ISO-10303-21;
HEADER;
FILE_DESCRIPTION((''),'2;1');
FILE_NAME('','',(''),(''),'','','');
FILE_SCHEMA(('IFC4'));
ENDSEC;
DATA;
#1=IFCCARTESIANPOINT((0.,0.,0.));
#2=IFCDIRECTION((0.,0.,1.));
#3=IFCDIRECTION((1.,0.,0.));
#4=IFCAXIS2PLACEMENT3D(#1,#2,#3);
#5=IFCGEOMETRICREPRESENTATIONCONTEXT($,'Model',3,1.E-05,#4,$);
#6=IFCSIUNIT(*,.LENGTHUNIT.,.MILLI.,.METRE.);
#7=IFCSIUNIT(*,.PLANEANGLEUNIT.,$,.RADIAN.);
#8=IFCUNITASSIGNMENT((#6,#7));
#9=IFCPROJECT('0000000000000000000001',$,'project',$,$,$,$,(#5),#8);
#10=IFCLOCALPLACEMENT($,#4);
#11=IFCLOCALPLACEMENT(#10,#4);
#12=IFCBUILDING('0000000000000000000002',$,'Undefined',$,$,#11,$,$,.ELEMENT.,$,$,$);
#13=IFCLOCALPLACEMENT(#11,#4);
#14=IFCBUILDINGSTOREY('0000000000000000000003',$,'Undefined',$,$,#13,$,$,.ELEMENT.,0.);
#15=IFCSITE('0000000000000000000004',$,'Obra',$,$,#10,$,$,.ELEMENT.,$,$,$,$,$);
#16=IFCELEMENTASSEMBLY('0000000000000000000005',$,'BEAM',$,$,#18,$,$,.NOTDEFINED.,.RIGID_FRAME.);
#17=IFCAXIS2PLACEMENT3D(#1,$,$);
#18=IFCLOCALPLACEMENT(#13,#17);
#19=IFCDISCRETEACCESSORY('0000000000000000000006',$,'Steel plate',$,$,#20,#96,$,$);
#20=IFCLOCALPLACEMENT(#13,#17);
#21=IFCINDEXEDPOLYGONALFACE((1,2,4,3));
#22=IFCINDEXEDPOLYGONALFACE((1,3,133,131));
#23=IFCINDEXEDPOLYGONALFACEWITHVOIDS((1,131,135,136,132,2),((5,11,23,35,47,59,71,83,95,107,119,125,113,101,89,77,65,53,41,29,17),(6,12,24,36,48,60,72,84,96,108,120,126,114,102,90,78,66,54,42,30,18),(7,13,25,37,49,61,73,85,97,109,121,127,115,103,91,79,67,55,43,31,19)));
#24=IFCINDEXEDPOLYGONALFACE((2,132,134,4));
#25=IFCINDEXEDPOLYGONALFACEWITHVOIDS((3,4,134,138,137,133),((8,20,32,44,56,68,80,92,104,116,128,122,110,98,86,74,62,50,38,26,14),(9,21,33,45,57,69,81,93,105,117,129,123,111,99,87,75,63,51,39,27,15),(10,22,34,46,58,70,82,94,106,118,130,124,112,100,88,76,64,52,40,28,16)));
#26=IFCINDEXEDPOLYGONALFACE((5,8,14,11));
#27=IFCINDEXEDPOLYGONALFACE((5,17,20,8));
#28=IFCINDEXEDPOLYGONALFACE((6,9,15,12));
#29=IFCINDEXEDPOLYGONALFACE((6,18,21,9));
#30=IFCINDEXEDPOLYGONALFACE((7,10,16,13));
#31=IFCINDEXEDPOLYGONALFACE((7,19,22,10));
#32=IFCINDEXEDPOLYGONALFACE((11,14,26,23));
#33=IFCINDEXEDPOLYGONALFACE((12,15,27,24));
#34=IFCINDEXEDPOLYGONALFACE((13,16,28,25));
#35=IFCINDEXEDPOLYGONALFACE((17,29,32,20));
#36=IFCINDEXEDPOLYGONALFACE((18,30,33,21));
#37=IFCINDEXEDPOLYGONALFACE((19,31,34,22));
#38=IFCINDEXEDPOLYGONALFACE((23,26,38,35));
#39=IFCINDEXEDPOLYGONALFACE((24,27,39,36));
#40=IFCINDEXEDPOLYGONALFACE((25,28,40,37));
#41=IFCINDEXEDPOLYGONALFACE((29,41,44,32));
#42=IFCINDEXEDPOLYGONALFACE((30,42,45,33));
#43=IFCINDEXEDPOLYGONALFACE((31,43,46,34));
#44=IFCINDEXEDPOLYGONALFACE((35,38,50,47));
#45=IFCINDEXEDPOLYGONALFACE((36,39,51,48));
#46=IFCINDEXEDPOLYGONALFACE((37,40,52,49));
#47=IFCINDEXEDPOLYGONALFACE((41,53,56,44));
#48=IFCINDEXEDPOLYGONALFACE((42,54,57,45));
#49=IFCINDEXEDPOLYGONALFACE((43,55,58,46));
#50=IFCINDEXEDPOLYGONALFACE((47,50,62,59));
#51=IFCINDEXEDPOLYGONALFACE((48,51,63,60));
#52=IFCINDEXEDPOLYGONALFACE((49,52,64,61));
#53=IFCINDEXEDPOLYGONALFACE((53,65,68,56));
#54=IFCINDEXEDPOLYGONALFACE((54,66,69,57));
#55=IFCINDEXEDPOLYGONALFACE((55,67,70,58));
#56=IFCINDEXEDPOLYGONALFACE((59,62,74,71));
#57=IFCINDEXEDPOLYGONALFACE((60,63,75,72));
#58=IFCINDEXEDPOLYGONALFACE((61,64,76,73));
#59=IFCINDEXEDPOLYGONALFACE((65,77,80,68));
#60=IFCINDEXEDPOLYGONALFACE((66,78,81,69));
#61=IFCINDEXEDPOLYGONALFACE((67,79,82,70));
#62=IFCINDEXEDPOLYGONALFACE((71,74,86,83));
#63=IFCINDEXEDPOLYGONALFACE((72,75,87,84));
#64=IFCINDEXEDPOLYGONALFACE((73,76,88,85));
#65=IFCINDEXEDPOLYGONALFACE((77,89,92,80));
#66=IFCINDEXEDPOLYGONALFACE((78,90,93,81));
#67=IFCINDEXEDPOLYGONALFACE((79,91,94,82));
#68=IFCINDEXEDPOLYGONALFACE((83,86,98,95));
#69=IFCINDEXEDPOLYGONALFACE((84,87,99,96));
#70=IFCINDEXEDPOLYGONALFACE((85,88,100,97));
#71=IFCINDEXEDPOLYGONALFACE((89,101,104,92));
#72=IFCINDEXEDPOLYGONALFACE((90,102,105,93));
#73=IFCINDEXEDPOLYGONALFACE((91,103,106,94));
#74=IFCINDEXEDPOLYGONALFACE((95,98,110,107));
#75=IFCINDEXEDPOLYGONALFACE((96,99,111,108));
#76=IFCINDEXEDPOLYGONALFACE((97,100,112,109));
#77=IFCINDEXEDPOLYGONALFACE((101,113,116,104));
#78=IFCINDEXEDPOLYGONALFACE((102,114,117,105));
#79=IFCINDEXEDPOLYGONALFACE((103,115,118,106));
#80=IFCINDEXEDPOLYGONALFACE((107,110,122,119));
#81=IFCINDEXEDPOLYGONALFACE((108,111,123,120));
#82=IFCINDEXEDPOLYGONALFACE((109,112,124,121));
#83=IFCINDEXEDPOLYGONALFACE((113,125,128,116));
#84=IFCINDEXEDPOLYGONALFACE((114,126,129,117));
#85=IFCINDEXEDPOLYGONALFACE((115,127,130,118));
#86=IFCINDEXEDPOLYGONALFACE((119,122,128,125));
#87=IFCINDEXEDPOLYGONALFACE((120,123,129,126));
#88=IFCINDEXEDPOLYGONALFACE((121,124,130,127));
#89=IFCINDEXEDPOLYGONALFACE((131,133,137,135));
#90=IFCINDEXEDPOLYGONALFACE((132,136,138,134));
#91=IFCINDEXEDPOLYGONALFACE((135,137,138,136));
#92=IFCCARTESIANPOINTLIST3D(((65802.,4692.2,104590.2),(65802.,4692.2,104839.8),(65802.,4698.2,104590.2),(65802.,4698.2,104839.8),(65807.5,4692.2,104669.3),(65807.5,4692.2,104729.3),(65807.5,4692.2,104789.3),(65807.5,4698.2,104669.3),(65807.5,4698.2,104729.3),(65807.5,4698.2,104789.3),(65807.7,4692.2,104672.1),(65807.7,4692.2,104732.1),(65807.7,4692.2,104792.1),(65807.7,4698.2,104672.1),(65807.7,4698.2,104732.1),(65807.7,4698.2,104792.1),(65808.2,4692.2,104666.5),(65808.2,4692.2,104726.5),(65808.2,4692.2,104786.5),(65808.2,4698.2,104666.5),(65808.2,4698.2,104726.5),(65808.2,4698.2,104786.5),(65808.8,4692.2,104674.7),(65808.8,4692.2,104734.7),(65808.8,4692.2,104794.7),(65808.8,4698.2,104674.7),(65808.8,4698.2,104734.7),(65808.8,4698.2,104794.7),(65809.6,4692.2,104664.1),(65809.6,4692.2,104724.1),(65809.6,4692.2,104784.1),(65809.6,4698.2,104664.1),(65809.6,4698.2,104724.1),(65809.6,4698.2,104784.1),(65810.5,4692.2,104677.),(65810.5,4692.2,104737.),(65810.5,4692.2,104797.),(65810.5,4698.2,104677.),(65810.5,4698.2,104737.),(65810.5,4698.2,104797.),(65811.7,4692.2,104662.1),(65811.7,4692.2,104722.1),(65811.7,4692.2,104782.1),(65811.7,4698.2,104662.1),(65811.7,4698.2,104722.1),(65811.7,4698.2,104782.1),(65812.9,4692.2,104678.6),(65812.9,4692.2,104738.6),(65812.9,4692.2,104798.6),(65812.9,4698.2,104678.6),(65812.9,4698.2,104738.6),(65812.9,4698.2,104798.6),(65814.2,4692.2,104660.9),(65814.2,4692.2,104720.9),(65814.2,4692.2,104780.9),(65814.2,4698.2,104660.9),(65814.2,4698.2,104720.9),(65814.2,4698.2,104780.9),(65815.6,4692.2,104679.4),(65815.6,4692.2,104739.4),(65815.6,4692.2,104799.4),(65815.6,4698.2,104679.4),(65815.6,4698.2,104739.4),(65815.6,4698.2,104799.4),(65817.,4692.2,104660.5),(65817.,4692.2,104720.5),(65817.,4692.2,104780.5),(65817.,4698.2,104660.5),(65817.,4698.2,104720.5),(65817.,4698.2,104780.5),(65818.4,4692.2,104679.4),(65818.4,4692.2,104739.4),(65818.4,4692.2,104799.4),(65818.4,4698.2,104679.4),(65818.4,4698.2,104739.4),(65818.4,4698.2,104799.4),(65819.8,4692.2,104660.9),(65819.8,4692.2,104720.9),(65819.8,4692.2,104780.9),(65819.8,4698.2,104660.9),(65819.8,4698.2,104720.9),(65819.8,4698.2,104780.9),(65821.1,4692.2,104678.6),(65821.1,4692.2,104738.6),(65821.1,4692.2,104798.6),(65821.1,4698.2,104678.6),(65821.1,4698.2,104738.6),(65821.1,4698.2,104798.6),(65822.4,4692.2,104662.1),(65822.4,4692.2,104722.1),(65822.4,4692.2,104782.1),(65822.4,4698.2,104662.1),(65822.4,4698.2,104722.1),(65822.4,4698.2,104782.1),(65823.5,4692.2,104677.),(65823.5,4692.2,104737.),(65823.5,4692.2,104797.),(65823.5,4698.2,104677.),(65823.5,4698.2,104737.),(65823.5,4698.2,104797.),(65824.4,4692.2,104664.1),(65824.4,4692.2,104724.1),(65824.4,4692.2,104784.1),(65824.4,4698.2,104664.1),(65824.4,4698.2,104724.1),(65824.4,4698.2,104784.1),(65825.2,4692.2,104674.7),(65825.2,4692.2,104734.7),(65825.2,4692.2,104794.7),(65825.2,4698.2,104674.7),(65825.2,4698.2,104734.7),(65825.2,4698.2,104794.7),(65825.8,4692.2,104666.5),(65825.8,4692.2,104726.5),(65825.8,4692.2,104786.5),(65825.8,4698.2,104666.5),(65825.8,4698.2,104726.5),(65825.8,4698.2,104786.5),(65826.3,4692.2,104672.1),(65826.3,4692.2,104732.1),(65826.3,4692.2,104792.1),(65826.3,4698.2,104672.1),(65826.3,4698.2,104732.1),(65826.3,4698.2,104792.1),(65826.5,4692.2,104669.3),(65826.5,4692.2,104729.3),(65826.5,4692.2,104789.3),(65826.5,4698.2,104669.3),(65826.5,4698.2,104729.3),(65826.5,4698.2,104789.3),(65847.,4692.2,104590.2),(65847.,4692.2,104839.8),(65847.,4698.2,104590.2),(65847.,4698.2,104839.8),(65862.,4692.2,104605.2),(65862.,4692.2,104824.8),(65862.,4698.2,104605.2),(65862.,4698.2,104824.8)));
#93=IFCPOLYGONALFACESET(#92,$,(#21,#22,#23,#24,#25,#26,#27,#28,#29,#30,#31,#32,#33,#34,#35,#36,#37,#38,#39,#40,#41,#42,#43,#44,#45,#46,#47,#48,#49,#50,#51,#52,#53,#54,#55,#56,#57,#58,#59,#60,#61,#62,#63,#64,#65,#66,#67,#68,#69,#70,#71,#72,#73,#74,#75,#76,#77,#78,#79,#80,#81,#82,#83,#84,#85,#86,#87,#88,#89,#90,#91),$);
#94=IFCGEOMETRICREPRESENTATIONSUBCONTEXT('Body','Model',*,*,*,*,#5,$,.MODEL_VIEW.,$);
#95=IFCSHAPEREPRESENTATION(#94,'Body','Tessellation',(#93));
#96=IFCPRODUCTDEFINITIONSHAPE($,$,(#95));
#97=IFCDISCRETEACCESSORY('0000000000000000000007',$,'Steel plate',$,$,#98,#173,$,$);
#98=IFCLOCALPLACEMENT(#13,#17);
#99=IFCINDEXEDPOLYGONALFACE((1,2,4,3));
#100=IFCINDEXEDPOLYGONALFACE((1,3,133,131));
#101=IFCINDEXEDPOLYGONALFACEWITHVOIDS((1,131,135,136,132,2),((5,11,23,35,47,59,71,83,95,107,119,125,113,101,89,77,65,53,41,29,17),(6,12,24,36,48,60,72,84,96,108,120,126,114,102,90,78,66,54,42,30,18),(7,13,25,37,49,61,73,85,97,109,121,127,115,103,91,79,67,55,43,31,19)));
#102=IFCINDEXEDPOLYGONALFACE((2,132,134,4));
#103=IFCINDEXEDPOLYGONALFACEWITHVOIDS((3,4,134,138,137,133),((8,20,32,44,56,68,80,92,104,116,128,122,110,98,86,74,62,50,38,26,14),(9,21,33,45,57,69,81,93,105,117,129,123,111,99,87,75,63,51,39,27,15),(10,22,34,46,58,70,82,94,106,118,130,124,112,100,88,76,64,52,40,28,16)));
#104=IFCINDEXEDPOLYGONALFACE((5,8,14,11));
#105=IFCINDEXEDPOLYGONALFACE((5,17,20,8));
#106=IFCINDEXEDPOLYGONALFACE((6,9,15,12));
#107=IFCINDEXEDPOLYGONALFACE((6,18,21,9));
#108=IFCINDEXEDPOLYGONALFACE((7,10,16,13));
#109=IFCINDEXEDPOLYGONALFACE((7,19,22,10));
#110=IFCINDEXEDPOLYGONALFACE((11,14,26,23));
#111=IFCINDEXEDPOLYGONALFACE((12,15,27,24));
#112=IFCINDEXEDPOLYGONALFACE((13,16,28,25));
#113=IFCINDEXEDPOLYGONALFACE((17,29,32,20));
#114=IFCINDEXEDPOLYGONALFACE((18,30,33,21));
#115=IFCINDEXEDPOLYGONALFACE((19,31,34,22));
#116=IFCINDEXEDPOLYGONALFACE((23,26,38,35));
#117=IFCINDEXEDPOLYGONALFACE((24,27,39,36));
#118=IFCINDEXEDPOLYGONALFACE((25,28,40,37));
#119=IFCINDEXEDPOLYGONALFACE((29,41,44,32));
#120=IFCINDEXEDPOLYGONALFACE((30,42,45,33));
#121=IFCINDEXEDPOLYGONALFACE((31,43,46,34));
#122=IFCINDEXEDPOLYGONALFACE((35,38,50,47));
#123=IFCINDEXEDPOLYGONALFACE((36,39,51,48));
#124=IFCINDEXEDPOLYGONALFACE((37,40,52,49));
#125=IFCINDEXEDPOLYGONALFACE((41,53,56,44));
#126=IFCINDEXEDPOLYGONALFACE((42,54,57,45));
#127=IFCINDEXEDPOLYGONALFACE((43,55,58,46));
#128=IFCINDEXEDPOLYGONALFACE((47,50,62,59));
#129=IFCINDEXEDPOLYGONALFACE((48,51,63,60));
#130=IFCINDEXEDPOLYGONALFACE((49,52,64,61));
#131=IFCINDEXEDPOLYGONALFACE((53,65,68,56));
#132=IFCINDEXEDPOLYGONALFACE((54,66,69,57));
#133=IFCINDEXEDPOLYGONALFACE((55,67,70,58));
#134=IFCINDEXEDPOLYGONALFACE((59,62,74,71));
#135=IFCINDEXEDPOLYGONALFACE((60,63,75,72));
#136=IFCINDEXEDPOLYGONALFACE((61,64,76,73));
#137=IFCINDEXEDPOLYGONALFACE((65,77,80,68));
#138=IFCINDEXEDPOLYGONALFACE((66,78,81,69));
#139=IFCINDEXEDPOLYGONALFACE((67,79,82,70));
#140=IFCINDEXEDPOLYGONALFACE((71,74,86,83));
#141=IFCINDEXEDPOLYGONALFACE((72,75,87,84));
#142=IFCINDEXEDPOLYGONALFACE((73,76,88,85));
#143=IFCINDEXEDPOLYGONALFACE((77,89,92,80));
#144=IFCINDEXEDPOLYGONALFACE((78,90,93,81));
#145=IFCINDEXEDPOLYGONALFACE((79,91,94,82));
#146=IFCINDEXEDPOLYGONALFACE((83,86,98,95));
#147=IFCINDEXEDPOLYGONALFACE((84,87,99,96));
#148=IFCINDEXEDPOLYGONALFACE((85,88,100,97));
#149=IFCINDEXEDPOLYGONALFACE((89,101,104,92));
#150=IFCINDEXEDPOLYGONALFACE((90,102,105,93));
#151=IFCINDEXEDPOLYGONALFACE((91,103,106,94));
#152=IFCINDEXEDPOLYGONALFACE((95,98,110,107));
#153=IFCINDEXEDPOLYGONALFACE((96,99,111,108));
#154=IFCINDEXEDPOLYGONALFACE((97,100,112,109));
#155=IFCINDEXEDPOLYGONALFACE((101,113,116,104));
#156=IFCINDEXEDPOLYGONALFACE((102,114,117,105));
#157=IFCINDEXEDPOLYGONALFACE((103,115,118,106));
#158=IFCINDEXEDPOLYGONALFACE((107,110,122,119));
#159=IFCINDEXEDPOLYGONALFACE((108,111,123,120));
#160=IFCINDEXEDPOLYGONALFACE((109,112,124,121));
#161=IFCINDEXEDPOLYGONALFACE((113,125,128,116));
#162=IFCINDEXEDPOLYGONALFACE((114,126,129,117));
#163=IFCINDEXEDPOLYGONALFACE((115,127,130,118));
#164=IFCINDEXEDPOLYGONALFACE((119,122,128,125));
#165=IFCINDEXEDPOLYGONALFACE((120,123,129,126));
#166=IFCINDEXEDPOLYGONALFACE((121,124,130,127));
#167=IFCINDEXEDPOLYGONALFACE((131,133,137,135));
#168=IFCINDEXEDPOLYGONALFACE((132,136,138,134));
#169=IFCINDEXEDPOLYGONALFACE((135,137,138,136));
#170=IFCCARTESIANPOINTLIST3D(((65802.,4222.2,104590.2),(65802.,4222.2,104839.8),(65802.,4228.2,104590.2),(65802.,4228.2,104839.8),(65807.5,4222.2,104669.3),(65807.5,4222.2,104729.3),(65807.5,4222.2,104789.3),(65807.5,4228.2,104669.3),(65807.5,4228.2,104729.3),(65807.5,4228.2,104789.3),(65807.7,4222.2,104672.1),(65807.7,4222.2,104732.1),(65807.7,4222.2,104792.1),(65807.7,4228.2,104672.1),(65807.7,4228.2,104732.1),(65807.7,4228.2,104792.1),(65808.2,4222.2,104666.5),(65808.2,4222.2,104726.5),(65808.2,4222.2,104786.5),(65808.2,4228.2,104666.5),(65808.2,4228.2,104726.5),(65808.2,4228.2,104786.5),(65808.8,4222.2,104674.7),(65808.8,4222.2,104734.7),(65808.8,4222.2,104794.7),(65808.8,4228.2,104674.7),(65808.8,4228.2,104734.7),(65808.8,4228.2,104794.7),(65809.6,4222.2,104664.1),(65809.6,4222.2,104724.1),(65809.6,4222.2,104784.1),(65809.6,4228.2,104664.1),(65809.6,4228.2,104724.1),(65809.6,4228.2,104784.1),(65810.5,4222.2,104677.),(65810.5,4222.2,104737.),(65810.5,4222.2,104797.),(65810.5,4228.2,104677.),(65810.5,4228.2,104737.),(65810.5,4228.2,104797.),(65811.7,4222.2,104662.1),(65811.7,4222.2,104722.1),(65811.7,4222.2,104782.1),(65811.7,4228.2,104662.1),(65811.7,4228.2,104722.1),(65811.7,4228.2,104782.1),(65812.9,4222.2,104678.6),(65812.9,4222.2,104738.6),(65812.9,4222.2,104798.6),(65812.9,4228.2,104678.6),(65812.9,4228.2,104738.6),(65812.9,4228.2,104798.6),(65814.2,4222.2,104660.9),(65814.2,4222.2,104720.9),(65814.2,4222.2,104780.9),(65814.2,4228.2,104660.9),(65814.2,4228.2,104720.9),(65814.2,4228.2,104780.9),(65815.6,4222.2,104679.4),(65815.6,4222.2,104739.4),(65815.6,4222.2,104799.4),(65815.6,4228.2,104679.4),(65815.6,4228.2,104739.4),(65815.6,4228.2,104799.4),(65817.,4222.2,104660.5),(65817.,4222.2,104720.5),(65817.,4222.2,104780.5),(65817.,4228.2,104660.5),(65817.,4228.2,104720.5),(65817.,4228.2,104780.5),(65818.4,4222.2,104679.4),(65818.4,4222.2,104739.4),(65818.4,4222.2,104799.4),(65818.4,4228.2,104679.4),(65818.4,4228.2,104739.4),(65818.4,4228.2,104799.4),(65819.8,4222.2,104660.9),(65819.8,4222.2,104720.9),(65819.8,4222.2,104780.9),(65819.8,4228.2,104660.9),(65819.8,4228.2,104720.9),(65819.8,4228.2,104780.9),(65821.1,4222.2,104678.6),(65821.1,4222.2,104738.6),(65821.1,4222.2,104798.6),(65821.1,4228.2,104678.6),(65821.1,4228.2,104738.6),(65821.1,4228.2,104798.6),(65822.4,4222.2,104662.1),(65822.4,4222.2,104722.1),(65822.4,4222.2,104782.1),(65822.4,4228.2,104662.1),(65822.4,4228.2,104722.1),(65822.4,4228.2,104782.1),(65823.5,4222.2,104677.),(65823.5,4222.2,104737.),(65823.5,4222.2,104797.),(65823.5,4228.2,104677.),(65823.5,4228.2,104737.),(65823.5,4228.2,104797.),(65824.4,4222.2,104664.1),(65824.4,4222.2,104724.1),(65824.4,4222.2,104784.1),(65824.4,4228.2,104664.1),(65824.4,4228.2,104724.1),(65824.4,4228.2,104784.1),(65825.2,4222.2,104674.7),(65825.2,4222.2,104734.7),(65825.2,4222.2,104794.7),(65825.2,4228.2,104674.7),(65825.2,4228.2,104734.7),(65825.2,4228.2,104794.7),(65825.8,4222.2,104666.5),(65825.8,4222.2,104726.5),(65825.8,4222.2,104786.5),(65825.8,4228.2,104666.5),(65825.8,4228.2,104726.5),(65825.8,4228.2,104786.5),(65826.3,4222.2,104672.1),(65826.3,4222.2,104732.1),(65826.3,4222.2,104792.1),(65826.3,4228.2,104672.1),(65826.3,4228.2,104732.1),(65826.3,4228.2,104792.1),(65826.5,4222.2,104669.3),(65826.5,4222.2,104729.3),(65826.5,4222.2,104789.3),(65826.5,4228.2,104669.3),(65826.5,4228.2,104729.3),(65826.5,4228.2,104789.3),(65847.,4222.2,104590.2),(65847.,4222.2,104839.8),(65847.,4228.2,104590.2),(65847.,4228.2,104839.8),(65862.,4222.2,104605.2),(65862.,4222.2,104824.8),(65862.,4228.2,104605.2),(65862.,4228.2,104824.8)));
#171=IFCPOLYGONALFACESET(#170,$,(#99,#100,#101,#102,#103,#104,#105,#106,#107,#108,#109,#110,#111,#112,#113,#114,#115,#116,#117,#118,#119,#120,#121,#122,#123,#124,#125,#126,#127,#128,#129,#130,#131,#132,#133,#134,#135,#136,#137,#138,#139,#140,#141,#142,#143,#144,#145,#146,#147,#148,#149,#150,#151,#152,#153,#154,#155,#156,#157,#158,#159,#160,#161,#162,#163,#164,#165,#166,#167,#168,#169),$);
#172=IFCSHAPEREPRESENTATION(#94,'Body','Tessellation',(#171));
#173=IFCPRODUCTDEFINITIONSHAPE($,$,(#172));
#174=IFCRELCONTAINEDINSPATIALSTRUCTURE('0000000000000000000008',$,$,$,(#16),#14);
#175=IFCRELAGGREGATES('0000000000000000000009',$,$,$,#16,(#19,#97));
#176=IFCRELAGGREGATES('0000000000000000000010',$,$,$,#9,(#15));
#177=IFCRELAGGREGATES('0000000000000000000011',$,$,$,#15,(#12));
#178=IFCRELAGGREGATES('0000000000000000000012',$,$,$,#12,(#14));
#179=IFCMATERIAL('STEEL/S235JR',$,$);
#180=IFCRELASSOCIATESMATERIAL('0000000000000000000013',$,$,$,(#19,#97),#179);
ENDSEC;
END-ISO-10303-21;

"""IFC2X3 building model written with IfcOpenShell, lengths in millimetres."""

from ifc_helpers import new_model, si_unit, frame, origin_with_axes, origin_2d_with_axis, place, context, subcontext, project, spatial, polyline, circle, outline, extrude, source, transform, mapped, material, element, aggregate, save


model = new_model("IFC2X3")

# Units and contexts
model_context = context("Model", 3, precision=1e-05, world=origin_with_axes())
body_context = subcontext(model_context, "Body", "Model", "MODEL_VIEW")
ifc_project = project(units=[si_unit("LENGTHUNIT", "METRE", prefix="MILLI"), si_unit("PLANEANGLEUNIT", "RADIAN")], contexts=[model_context])

# Site, building, storey
site_placement = place(None, origin_with_axes())
site = spatial("IfcSite", under=ifc_project, at=site_placement, Name="Obra", CompositionType="ELEMENT")
building_placement = place(site_placement, origin_with_axes())
building = spatial("IfcBuilding", under=site, at=building_placement, Name="Undefined", CompositionType="ELEMENT")
storey_placement = place(building_placement, origin_with_axes())
storey = spatial("IfcBuildingStorey", under=building, at=storey_placement, Name="Undefined", CompositionType="ELEMENT", Elevation=0.0)

# Element assembly, discrete accessories, openings
ifc_material = material(Name="STEEL/S235JR")
shared_shape_1 = source(origin_with_axes(), body_context, "Body", "SweptSolid", [
    extrude(circle(Radius=9.5, at=origin_2d_with_axis()), frame((0.0, -9.2, 0.0), z_axis=(0.0, 1.0, 0.0), x_axis=(1.0, 0.0, 0.0)), (0.0, 0.0, 1.0), 6.2),
])
assembly_1_placement = place(storey_placement, origin_with_axes())
assembly_1 = element("IfcElementAssembly", 1, at=assembly_1_placement, inside=storey, Name="BEAM", AssemblyPlace="NOTDEFINED", PredefinedType="RIGID_FRAME")
discrete_accessory_1_placement = place(assembly_1_placement, frame((65802.0, 4695.2, 104590.2), z_axis=(0.0, -1.0, 0.0), x_axis=(1.0, 0.0, 0.0)))
discrete_accessory_1 = element("IfcDiscreteAccessory", 2, at=discrete_accessory_1_placement, material=ifc_material, Name="Steel plate", context=body_context, shape_type="SweptSolid", body=[
    extrude(outline(polyline([(0.0, 0.0), (45.0, 0.0), (60.0, 15.0), (60.0, 234.6), (45.0, 249.6), (0.0, 249.6), (0.0, 0.0)])), frame((0.0, 0.0, -3.0), z_axis=(0.0, 0.0, 1.0), x_axis=(1.0, 0.0, 0.0)), (0.0, 0.0, 1.0), 6.0),
])
opening_1_placement = place(assembly_1_placement, frame((65852.0, 4689.1, 104850.0), z_axis=(-1.0, 0.0, 0.0), x_axis=(0.0, 0.0, -1.0)))
element("IfcOpeningElement", 3, at=opening_1_placement, cuts=discrete_accessory_1, ObjectType="Opening", context=body_context, shape_type="MappedRepresentation", body=[
    mapped(shared_shape_1, transform((60.0, 0.0, 35.0))),
    mapped(shared_shape_1, transform((120.0, 0.0, 35.0))),
    mapped(shared_shape_1, transform((180.0, 0.0, 35.0))),
])
discrete_accessory_2_placement = place(assembly_1_placement, frame((65802.0, 4225.2, 104590.2), z_axis=(0.0, -1.0, 0.0), x_axis=(1.0, 0.0, 0.0)))
discrete_accessory_2 = element("IfcDiscreteAccessory", 4, at=discrete_accessory_2_placement, material=ifc_material, Name="Steel plate", context=body_context, shape_type="SweptSolid", body=[
    extrude(outline(polyline([(0.0, 0.0), (45.0, 0.0), (60.0, 15.0), (60.0, 234.6), (45.0, 249.6), (0.0, 249.6), (0.0, 0.0)])), frame((0.0, 0.0, -3.0), z_axis=(0.0, 0.0, 1.0), x_axis=(1.0, 0.0, 0.0)), (0.0, 0.0, 1.0), 6.0),
])
opening_2_placement = place(assembly_1_placement, frame((65852.0, 4219.1, 104850.0), z_axis=(-1.0, 0.0, 0.0), x_axis=(0.0, 0.0, -1.0)))
element("IfcOpeningElement", 5, at=opening_2_placement, cuts=discrete_accessory_2, ObjectType="Opening", context=body_context, shape_type="MappedRepresentation", body=[
    mapped(shared_shape_1, transform((60.0, 0.0, 35.0))),
    mapped(shared_shape_1, transform((120.0, 0.0, 35.0))),
    mapped(shared_shape_1, transform((180.0, 0.0, 35.0))),
])
aggregate(assembly_1, [discrete_accessory_1, discrete_accessory_2])

save(model, "model.ifc")
